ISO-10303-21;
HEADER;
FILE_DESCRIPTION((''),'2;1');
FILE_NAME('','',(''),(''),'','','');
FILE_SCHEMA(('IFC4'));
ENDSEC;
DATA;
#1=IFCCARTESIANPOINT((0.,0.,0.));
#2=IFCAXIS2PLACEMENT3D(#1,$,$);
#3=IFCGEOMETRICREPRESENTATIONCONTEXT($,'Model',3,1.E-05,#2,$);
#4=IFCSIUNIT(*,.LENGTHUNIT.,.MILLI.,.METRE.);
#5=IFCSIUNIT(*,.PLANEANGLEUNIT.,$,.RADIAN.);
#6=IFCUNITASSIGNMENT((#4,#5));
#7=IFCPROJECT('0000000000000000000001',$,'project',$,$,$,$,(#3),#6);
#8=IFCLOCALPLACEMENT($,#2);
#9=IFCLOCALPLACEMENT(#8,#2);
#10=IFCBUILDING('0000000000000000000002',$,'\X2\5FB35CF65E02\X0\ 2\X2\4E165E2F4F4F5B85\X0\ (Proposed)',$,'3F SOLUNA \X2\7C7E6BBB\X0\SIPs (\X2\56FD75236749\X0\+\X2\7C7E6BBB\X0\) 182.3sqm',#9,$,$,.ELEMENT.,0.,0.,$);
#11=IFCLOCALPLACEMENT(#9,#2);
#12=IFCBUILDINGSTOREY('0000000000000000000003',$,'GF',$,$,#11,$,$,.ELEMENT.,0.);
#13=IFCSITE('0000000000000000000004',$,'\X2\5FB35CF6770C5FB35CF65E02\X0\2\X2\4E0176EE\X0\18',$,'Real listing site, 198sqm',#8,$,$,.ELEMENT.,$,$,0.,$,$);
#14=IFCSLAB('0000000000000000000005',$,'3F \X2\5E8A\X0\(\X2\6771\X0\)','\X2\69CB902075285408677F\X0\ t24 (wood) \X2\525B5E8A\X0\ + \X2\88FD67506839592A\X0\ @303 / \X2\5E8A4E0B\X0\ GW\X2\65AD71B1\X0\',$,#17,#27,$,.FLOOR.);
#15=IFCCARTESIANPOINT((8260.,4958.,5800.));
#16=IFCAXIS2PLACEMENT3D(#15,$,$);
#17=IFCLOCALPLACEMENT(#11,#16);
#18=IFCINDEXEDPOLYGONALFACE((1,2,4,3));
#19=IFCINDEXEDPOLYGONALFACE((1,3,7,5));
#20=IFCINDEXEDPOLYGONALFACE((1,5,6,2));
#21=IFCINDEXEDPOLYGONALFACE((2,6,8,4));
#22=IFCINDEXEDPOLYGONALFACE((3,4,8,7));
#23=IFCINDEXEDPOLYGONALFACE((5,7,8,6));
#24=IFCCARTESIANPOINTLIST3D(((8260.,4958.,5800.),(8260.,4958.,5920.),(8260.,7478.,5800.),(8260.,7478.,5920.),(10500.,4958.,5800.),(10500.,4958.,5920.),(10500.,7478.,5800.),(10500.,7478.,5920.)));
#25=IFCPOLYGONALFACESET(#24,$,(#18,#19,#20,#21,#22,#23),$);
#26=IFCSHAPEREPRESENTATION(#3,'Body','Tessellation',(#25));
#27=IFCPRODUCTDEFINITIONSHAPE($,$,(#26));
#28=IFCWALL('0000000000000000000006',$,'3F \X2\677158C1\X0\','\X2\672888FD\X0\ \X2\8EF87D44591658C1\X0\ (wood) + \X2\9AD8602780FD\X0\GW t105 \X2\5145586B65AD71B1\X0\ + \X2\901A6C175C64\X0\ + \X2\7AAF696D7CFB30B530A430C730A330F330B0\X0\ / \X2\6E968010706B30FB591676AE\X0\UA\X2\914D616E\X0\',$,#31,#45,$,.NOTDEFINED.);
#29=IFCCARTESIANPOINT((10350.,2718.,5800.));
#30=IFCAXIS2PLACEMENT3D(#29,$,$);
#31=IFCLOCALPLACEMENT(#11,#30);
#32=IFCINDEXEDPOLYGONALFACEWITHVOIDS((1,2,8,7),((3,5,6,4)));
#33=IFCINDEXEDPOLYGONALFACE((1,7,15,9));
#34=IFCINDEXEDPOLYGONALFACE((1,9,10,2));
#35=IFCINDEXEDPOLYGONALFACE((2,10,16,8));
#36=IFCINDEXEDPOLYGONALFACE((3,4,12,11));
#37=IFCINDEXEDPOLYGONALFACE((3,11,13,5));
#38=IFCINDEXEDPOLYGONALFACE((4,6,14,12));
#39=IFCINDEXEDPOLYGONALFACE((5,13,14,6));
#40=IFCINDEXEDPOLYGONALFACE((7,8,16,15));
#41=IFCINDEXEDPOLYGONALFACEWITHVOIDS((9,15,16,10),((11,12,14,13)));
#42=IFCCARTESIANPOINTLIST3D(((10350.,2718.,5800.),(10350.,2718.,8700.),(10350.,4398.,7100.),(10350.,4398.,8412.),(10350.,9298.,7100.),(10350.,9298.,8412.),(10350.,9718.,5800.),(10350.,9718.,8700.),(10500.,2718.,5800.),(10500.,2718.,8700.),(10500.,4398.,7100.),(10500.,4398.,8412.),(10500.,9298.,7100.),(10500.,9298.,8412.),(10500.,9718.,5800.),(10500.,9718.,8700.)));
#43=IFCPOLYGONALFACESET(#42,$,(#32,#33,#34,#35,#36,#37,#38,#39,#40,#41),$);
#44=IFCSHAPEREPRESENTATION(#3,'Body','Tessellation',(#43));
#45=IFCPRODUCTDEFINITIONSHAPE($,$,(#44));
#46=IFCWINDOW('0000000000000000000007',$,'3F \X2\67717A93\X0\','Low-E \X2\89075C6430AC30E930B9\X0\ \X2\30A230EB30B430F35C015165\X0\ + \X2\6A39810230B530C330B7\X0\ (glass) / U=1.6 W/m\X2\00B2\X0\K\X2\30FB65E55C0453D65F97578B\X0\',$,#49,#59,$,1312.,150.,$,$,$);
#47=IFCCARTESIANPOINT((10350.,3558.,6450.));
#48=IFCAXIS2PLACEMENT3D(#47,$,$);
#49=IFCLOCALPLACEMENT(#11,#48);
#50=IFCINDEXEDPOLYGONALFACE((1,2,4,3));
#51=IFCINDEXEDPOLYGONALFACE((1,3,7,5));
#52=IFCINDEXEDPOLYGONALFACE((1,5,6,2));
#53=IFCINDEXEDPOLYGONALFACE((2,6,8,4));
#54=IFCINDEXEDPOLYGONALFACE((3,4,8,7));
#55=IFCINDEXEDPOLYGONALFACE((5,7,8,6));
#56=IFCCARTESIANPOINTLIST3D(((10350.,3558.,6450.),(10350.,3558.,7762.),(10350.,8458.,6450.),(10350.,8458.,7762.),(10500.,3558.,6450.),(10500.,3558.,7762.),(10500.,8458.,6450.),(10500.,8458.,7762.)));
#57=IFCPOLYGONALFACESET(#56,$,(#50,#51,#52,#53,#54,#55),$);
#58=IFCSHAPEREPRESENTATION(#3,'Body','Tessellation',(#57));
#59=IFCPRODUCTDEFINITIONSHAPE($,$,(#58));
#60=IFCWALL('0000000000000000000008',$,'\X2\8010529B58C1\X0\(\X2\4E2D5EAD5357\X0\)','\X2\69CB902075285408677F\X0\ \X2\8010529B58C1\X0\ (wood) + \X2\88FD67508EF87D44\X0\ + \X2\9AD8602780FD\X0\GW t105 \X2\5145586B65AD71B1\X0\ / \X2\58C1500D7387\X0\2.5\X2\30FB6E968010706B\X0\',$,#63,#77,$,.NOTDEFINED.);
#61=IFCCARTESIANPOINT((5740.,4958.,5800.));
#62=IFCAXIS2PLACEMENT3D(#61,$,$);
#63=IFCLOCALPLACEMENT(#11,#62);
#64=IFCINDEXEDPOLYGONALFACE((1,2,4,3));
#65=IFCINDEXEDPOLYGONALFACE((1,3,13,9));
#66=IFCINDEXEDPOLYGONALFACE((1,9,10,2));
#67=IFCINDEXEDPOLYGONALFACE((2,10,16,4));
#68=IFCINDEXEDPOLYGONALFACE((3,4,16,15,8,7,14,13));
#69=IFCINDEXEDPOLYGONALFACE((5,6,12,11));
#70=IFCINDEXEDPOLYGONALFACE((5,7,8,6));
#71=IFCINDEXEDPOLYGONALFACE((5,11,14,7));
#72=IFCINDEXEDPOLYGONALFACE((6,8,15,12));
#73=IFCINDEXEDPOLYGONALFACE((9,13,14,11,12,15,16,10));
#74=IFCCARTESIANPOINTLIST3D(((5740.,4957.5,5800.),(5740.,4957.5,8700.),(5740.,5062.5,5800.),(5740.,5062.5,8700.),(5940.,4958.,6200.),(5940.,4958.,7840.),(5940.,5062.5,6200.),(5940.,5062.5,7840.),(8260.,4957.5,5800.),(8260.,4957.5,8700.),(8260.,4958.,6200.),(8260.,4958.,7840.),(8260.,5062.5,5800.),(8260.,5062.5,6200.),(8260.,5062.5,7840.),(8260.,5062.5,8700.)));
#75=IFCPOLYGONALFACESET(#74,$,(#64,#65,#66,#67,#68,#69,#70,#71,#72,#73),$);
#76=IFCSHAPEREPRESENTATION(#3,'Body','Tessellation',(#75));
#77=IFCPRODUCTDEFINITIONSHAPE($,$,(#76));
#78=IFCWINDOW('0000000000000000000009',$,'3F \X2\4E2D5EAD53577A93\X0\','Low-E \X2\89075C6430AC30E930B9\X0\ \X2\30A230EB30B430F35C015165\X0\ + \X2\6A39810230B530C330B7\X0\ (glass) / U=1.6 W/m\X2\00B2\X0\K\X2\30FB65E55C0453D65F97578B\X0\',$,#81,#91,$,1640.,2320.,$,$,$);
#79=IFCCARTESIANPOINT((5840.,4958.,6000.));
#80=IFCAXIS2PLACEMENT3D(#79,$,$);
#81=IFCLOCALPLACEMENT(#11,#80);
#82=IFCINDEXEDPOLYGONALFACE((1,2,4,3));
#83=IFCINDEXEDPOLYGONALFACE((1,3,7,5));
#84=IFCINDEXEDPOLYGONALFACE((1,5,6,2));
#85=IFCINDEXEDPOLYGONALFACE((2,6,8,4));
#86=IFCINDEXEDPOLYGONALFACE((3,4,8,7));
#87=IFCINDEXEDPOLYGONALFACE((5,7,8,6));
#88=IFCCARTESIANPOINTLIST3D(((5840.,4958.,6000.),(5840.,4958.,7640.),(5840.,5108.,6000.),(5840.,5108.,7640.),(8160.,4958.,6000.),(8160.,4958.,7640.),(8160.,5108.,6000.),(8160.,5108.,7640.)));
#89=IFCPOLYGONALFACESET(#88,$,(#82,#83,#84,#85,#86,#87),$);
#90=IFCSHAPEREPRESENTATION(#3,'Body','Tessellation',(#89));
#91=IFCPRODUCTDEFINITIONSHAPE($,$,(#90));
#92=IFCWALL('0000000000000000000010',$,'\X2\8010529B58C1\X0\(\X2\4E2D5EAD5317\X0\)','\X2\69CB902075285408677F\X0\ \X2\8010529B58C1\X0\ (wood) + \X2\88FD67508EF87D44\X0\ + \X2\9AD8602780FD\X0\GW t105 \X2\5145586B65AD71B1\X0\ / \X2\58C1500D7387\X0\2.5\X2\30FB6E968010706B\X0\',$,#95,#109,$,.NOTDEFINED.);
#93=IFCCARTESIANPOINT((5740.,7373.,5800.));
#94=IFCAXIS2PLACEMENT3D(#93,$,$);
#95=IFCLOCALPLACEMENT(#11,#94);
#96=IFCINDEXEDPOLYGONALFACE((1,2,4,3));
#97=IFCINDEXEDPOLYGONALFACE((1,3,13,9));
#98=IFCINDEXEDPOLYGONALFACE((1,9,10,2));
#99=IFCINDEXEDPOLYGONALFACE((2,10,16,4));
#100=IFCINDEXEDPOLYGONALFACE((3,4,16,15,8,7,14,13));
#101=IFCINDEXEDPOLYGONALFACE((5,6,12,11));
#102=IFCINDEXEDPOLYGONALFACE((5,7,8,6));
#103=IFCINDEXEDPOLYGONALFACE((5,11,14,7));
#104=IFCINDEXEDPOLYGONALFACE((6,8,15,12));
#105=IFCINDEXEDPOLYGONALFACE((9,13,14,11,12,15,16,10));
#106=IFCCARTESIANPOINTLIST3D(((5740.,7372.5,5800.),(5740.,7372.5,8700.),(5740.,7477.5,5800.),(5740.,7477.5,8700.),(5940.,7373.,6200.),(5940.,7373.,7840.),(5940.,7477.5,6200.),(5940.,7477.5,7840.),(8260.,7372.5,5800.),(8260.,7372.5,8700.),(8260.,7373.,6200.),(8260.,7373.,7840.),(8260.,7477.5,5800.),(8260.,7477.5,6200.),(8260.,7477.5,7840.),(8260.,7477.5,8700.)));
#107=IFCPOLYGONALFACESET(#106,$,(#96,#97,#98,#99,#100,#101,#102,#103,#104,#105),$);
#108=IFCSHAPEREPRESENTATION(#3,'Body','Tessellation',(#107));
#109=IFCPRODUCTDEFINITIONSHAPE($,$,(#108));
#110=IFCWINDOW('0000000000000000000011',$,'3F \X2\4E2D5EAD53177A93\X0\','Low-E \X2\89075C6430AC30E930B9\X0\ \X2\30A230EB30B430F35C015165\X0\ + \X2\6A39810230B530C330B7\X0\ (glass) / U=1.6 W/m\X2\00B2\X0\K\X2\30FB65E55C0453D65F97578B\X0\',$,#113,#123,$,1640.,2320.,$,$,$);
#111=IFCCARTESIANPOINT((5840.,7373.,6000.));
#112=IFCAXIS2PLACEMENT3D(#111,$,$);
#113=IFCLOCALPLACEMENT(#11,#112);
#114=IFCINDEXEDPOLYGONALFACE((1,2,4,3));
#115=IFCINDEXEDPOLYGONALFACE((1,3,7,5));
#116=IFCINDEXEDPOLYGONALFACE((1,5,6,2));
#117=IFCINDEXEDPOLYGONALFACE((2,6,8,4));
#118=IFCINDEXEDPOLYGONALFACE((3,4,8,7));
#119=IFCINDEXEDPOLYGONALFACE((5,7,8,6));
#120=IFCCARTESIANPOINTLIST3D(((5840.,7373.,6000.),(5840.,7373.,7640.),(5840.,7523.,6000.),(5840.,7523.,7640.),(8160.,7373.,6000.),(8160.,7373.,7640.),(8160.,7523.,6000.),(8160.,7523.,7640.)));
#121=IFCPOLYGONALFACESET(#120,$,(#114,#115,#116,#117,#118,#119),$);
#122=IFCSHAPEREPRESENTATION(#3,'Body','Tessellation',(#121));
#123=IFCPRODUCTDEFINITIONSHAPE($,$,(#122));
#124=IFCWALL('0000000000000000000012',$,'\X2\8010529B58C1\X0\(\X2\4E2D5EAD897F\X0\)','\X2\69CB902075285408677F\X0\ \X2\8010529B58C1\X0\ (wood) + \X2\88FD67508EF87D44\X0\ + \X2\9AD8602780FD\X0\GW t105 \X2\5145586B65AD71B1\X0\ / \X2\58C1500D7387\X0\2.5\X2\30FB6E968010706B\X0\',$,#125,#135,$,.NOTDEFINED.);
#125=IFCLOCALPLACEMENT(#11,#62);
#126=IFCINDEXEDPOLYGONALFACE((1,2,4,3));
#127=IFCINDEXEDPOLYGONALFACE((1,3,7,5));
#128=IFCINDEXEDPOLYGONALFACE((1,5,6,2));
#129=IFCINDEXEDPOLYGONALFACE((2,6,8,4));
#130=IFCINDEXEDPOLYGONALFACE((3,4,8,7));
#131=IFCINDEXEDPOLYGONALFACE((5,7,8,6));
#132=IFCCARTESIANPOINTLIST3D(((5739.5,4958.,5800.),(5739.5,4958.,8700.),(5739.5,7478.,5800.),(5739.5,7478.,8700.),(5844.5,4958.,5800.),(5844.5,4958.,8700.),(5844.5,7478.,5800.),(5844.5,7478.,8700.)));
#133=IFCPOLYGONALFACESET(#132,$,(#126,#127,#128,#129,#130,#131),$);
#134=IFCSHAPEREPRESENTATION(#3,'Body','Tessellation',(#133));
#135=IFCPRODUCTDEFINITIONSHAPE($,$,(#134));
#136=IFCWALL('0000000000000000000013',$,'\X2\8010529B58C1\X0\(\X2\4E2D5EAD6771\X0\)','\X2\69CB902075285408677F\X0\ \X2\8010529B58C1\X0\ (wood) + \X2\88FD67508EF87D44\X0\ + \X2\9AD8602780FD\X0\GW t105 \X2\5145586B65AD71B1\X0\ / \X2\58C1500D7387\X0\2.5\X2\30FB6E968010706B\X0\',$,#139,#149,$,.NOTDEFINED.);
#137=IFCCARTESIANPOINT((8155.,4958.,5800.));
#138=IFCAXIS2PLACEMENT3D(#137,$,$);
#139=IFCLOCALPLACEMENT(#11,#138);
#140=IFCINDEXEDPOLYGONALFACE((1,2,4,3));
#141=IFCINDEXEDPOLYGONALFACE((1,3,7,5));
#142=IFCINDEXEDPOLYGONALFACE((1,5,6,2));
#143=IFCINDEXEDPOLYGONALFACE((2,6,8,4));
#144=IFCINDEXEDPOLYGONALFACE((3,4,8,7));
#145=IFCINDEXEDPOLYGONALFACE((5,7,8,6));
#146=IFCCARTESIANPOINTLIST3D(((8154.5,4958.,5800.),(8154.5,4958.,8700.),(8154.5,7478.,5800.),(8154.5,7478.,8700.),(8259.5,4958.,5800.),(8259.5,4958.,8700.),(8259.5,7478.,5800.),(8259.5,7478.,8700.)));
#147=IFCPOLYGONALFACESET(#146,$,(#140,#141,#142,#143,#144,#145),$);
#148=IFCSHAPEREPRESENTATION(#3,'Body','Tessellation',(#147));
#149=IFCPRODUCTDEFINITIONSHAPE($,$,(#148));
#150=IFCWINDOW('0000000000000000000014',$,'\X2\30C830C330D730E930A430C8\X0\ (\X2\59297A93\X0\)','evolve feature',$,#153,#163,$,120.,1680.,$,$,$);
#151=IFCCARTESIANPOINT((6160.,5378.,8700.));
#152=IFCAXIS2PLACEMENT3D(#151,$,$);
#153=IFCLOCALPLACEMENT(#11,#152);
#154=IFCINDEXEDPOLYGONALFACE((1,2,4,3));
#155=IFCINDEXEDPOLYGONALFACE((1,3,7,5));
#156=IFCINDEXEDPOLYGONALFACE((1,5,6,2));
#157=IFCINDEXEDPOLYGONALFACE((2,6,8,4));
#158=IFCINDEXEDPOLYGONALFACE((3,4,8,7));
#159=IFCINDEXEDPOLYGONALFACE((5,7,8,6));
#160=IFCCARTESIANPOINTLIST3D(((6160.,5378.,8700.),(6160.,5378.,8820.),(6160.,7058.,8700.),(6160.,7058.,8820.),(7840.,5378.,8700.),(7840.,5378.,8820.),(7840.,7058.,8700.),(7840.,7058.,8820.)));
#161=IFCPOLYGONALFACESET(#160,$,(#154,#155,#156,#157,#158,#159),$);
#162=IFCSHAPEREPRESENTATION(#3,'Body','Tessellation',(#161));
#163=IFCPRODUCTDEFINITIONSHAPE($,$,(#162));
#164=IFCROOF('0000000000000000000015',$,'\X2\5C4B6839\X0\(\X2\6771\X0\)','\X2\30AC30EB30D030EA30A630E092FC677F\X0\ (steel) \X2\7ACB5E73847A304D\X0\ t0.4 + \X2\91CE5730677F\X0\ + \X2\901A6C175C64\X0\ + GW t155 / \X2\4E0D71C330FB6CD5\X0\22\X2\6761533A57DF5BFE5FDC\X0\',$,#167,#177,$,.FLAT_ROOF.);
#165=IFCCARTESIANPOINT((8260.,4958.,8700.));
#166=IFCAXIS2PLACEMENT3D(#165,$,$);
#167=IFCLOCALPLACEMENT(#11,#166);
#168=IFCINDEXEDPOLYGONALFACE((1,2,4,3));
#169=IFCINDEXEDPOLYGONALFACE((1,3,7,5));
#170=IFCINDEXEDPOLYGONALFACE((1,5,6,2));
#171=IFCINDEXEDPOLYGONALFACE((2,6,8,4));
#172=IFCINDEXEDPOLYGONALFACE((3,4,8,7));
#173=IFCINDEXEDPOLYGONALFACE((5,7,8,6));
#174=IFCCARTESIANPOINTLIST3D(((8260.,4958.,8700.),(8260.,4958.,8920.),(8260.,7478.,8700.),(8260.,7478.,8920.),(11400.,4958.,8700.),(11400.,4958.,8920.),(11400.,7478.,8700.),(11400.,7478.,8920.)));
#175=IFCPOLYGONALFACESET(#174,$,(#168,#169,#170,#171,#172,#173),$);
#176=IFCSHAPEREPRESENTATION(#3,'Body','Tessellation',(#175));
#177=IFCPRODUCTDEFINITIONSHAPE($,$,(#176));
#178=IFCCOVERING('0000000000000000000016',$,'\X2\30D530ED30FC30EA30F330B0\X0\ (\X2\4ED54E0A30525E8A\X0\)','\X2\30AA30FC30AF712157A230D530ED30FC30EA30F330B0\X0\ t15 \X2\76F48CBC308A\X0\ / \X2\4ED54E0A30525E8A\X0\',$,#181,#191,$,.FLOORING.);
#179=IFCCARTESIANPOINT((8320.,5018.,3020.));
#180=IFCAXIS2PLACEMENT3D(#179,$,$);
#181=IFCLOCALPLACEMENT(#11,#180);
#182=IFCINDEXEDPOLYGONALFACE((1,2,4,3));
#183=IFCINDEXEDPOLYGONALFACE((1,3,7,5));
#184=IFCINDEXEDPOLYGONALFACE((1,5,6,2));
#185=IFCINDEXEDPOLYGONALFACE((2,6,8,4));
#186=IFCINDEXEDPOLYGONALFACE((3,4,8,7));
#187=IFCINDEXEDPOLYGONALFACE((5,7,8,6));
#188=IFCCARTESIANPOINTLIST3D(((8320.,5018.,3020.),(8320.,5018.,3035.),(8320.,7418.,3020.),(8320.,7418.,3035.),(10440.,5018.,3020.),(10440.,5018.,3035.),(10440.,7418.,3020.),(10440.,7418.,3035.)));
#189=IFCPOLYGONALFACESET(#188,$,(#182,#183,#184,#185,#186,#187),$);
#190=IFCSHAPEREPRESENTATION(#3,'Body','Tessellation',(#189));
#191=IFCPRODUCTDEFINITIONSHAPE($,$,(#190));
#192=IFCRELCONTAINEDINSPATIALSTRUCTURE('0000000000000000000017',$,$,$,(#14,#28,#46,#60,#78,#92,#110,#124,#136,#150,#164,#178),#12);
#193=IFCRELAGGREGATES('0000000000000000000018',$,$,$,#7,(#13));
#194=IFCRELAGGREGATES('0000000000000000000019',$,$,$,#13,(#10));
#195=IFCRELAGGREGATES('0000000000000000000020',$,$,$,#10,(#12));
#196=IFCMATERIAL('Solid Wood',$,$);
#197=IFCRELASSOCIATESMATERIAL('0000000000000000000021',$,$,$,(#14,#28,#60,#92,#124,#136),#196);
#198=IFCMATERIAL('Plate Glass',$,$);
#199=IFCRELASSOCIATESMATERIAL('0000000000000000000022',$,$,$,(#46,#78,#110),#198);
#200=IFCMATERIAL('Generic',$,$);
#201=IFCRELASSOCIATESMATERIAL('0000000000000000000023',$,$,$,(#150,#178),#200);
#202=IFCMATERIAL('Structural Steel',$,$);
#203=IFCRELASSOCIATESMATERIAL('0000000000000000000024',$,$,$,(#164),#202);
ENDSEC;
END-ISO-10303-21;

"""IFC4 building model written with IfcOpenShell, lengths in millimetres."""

from ifc_helpers import new_model, si_unit, frame, frame_2d, origin, place, context, project, spatial, rectangle, extrude, material, element, fill, save


model = new_model("IFC4")

# Units and contexts
model_context = context("Model", 3, precision=1e-05, world=origin())
ifc_project = project(units=[si_unit("LENGTHUNIT", "METRE", prefix="MILLI"), si_unit("PLANEANGLEUNIT", "RADIAN")], contexts=[model_context])

# Site, building, storey
site_placement = place(None, origin())
site = spatial("IfcSite", under=ifc_project, at=site_placement, Name="徳島県徳島市2丁目18", ObjectType="Real listing site, 198sqm", CompositionType="ELEMENT", RefElevation=0.0)
building_placement = place(site_placement, origin())
building = spatial("IfcBuilding", under=site, at=building_placement, Name="徳島市 2世帯住宅 (Proposed)", ObjectType="3F SOLUNA 籾殻SIPs (国産杉+籾殻) 182.3sqm", CompositionType="ELEMENT", ElevationOfRefHeight=0.0, ElevationOfTerrain=0.0)
storey_placement = place(building_placement, origin())
storey = spatial("IfcBuildingStorey", under=building, at=storey_placement, Name="GF", CompositionType="ELEMENT", Elevation=0.0)

# Slab
ifc_material_1 = material(Name="Solid Wood")
slab_placement = place(storey_placement, frame((8260.0, 4958.0, 5800.0)))
element("IfcSlab", 1, at=slab_placement, inside=storey, material=ifc_material_1, Name="3F 床(東)", Description="構造用合板 t24 (wood) 剛床 + 製材根太 @303 / 床下 GW断熱", PredefinedType="FLOOR", context=model_context, shape_type="SweptSolid", body=[
    extrude(rectangle(XDim=2240.0, YDim=2520.0, at=frame_2d((1120.0, 1260.0))), frame((8260.0, 4958.0, 5800.0)), (0.0, 0.0, 1.0), 120.0),
])

# Walls, openings, windows
wall_1_placement = place(storey_placement, frame((10350.0, 2718.0, 5800.0)))
wall_1 = element("IfcWall", 2, at=wall_1_placement, inside=storey, material=ifc_material_1, Name="3F 東壁", Description="木製 軸組外壁 (wood) + 高性能GW t105 充填断熱 + 通気層 + 窯業系サイディング / 準耐火・外皮UA配慮", PredefinedType="NOTDEFINED", context=model_context, shape_type="SweptSolid", body=[
    extrude(rectangle(XDim=150.0, YDim=7000.0, at=frame_2d((75.0, 3500.0))), frame((10350.0, 2718.0, 5800.0)), (0.0, 0.0, 1.0), 2900.0),
])
opening_1_placement = place(storey_placement, frame((10350.0, 3558.0, 6450.0)))
opening_1 = element("IfcOpeningElement", 3, at=opening_1_placement, cuts=wall_1, PredefinedType="NOTDEFINED", context=model_context, shape_type="SweptSolid", body=[
    extrude(rectangle(XDim=150.0, YDim=4900.0, at=frame_2d((75.0, 2450.0))), frame((10350.0, 3558.0, 6450.0)), (0.0, 0.0, 1.0), 1312.0),
])
ifc_material_2 = material(Name="Plate Glass")
window_1_placement = place(storey_placement, frame((10350.0, 3558.0, 6450.0)))
window_1 = element("IfcWindow", 4, at=window_1_placement, inside=storey, material=ifc_material_2, Name="3F 東窓", Description="Low-E 複層ガラス アルゴン封入 + 樹脂サッシ (glass) / U=1.6 W/m²K・日射取得型", OverallHeight=1312.0, OverallWidth=150.0, context=model_context, shape_type="SweptSolid", body=[
    extrude(rectangle(XDim=150.0, YDim=4900.0, at=frame_2d((75.0, 2450.0))), frame((10350.0, 3558.0, 6450.0)), (0.0, 0.0, 1.0), 1312.0),
])
fill(opening_1, window_1)
wall_2_placement = place(storey_placement, frame((5740.0, 4958.0, 5800.0)))
wall_2 = element("IfcWall", 5, at=wall_2_placement, inside=storey, material=ifc_material_1, Name="耐力壁(中庭南)", Description="構造用合板 耐力壁 (wood) + 製材軸組 + 高性能GW t105 充填断熱 / 壁倍率2.5・準耐火", PredefinedType="NOTDEFINED", context=model_context, shape_type="SweptSolid", body=[
    extrude(rectangle(XDim=2520.0, YDim=105.0, at=frame_2d((1260.0, 52.0))), frame((5740.0, 4958.0, 5800.0)), (0.0, 0.0, 1.0), 2900.0),
])
opening_2_placement = place(storey_placement, frame((5840.0, 4958.0, 6000.0)))
opening_2 = element("IfcOpeningElement", 6, at=opening_2_placement, cuts=wall_2, PredefinedType="NOTDEFINED", context=model_context, shape_type="SweptSolid", body=[
    extrude(rectangle(XDim=2320.0, YDim=150.0, at=frame_2d((1160.0, 75.0))), frame((5840.0, 4958.0, 6000.0)), (0.0, 0.0, 1.0), 1640.0),
])
window_2_placement = place(storey_placement, frame((5840.0, 4958.0, 6000.0)))
window_2 = element("IfcWindow", 7, at=window_2_placement, inside=storey, material=ifc_material_2, Name="3F 中庭南窓", Description="Low-E 複層ガラス アルゴン封入 + 樹脂サッシ (glass) / U=1.6 W/m²K・日射取得型", OverallHeight=1640.0, OverallWidth=2320.0, context=model_context, shape_type="SweptSolid", body=[
    extrude(rectangle(XDim=2320.0, YDim=150.0, at=frame_2d((1160.0, 75.0))), frame((5840.0, 4958.0, 6000.0)), (0.0, 0.0, 1.0), 1640.0),
])
fill(opening_2, window_2)
wall_3_placement = place(storey_placement, frame((5740.0, 7373.0, 5800.0)))
wall_3 = element("IfcWall", 8, at=wall_3_placement, inside=storey, material=ifc_material_1, Name="耐力壁(中庭北)", Description="構造用合板 耐力壁 (wood) + 製材軸組 + 高性能GW t105 充填断熱 / 壁倍率2.5・準耐火", PredefinedType="NOTDEFINED", context=model_context, shape_type="SweptSolid", body=[
    extrude(rectangle(XDim=2520.0, YDim=105.0, at=frame_2d((1260.0, 52.0))), frame((5740.0, 7373.0, 5800.0)), (0.0, 0.0, 1.0), 2900.0),
])
opening_3_placement = place(storey_placement, frame((5840.0, 7373.0, 6000.0)))
opening_3 = element("IfcOpeningElement", 9, at=opening_3_placement, cuts=wall_3, PredefinedType="NOTDEFINED", context=model_context, shape_type="SweptSolid", body=[
    extrude(rectangle(XDim=2320.0, YDim=150.0, at=frame_2d((1160.0, 75.0))), frame((5840.0, 7373.0, 6000.0)), (0.0, 0.0, 1.0), 1640.0),
])
window_3_placement = place(storey_placement, frame((5840.0, 7373.0, 6000.0)))
window_3 = element("IfcWindow", 10, at=window_3_placement, inside=storey, material=ifc_material_2, Name="3F 中庭北窓", Description="Low-E 複層ガラス アルゴン封入 + 樹脂サッシ (glass) / U=1.6 W/m²K・日射取得型", OverallHeight=1640.0, OverallWidth=2320.0, context=model_context, shape_type="SweptSolid", body=[
    extrude(rectangle(XDim=2320.0, YDim=150.0, at=frame_2d((1160.0, 75.0))), frame((5840.0, 7373.0, 6000.0)), (0.0, 0.0, 1.0), 1640.0),
])
fill(opening_3, window_3)

# Walls
wall_4_placement = place(storey_placement, frame((5740.0, 4958.0, 5800.0)))
element("IfcWall", 11, at=wall_4_placement, inside=storey, material=ifc_material_1, Name="耐力壁(中庭西)", Description="構造用合板 耐力壁 (wood) + 製材軸組 + 高性能GW t105 充填断熱 / 壁倍率2.5・準耐火", PredefinedType="NOTDEFINED", context=model_context, shape_type="SweptSolid", body=[
    extrude(rectangle(XDim=105.0, YDim=2520.0, at=frame_2d((52.0, 1260.0))), frame((5740.0, 4958.0, 5800.0)), (0.0, 0.0, 1.0), 2900.0),
])
wall_5_placement = place(storey_placement, frame((8155.0, 4958.0, 5800.0)))
element("IfcWall", 12, at=wall_5_placement, inside=storey, material=ifc_material_1, Name="耐力壁(中庭東)", Description="構造用合板 耐力壁 (wood) + 製材軸組 + 高性能GW t105 充填断熱 / 壁倍率2.5・準耐火", PredefinedType="NOTDEFINED", context=model_context, shape_type="SweptSolid", body=[
    extrude(rectangle(XDim=105.0, YDim=2520.0, at=frame_2d((52.0, 1260.0))), frame((8155.0, 4958.0, 5800.0)), (0.0, 0.0, 1.0), 2900.0),
])

# Window
ifc_material_3 = material(Name="Generic")
window_4_placement = place(storey_placement, frame((6160.0, 5378.0, 8700.0)))
element("IfcWindow", 13, at=window_4_placement, inside=storey, material=ifc_material_3, Name="トップライト (天窓)", Description="evolve feature", OverallHeight=120.0, OverallWidth=1680.0, context=model_context, shape_type="SweptSolid", body=[
    extrude(rectangle(XDim=1680.0, YDim=1680.0, at=frame_2d((840.0, 840.0))), frame((6160.0, 5378.0, 8700.0)), (0.0, 0.0, 1.0), 120.0),
])

# Roof
ifc_material_4 = material(Name="Structural Steel")
for number, where, name in (
    (14, (8260.0, 4958.0, 8700.0), "屋根(東)"),
):
    element("IfcRoof", number, at=place(storey_placement, frame(where)), inside=storey, material=ifc_material_4, Name=name, Description="ガルバリウム鋼板 (steel) 立平葺き t0.4 + 野地板 + 通気層 + GW t155 / 不燃・法22条区域対応", PredefinedType="FLAT_ROOF", context=model_context, shape_type="SweptSolid", body=[
        extrude(rectangle(XDim=3140.0, YDim=2520.0, at=frame_2d((1570.0, 1260.0))), frame((8260.0, 4958.0, 8700.0)), (0.0, 0.0, 1.0), 220.0),
    ])

# Covering
covering_1_placement = place(storey_placement, frame((8320.0, 5018.0, 3020.0)))
element("IfcCovering", 15, at=covering_1_placement, inside=storey, material=ifc_material_3, Name="フローリング (仕上げ床)", Description="オーク無垢フローリング t15 直貼り / 仕上げ床", PredefinedType="FLOORING", context=model_context, shape_type="SweptSolid", body=[
    extrude(rectangle(XDim=2120.0, YDim=2400.0, at=frame_2d((1060.0, 1200.0))), frame((8320.0, 5018.0, 3020.0)), (0.0, 0.0, 1.0), 15.0),
])

save(model, "model.ifc")
